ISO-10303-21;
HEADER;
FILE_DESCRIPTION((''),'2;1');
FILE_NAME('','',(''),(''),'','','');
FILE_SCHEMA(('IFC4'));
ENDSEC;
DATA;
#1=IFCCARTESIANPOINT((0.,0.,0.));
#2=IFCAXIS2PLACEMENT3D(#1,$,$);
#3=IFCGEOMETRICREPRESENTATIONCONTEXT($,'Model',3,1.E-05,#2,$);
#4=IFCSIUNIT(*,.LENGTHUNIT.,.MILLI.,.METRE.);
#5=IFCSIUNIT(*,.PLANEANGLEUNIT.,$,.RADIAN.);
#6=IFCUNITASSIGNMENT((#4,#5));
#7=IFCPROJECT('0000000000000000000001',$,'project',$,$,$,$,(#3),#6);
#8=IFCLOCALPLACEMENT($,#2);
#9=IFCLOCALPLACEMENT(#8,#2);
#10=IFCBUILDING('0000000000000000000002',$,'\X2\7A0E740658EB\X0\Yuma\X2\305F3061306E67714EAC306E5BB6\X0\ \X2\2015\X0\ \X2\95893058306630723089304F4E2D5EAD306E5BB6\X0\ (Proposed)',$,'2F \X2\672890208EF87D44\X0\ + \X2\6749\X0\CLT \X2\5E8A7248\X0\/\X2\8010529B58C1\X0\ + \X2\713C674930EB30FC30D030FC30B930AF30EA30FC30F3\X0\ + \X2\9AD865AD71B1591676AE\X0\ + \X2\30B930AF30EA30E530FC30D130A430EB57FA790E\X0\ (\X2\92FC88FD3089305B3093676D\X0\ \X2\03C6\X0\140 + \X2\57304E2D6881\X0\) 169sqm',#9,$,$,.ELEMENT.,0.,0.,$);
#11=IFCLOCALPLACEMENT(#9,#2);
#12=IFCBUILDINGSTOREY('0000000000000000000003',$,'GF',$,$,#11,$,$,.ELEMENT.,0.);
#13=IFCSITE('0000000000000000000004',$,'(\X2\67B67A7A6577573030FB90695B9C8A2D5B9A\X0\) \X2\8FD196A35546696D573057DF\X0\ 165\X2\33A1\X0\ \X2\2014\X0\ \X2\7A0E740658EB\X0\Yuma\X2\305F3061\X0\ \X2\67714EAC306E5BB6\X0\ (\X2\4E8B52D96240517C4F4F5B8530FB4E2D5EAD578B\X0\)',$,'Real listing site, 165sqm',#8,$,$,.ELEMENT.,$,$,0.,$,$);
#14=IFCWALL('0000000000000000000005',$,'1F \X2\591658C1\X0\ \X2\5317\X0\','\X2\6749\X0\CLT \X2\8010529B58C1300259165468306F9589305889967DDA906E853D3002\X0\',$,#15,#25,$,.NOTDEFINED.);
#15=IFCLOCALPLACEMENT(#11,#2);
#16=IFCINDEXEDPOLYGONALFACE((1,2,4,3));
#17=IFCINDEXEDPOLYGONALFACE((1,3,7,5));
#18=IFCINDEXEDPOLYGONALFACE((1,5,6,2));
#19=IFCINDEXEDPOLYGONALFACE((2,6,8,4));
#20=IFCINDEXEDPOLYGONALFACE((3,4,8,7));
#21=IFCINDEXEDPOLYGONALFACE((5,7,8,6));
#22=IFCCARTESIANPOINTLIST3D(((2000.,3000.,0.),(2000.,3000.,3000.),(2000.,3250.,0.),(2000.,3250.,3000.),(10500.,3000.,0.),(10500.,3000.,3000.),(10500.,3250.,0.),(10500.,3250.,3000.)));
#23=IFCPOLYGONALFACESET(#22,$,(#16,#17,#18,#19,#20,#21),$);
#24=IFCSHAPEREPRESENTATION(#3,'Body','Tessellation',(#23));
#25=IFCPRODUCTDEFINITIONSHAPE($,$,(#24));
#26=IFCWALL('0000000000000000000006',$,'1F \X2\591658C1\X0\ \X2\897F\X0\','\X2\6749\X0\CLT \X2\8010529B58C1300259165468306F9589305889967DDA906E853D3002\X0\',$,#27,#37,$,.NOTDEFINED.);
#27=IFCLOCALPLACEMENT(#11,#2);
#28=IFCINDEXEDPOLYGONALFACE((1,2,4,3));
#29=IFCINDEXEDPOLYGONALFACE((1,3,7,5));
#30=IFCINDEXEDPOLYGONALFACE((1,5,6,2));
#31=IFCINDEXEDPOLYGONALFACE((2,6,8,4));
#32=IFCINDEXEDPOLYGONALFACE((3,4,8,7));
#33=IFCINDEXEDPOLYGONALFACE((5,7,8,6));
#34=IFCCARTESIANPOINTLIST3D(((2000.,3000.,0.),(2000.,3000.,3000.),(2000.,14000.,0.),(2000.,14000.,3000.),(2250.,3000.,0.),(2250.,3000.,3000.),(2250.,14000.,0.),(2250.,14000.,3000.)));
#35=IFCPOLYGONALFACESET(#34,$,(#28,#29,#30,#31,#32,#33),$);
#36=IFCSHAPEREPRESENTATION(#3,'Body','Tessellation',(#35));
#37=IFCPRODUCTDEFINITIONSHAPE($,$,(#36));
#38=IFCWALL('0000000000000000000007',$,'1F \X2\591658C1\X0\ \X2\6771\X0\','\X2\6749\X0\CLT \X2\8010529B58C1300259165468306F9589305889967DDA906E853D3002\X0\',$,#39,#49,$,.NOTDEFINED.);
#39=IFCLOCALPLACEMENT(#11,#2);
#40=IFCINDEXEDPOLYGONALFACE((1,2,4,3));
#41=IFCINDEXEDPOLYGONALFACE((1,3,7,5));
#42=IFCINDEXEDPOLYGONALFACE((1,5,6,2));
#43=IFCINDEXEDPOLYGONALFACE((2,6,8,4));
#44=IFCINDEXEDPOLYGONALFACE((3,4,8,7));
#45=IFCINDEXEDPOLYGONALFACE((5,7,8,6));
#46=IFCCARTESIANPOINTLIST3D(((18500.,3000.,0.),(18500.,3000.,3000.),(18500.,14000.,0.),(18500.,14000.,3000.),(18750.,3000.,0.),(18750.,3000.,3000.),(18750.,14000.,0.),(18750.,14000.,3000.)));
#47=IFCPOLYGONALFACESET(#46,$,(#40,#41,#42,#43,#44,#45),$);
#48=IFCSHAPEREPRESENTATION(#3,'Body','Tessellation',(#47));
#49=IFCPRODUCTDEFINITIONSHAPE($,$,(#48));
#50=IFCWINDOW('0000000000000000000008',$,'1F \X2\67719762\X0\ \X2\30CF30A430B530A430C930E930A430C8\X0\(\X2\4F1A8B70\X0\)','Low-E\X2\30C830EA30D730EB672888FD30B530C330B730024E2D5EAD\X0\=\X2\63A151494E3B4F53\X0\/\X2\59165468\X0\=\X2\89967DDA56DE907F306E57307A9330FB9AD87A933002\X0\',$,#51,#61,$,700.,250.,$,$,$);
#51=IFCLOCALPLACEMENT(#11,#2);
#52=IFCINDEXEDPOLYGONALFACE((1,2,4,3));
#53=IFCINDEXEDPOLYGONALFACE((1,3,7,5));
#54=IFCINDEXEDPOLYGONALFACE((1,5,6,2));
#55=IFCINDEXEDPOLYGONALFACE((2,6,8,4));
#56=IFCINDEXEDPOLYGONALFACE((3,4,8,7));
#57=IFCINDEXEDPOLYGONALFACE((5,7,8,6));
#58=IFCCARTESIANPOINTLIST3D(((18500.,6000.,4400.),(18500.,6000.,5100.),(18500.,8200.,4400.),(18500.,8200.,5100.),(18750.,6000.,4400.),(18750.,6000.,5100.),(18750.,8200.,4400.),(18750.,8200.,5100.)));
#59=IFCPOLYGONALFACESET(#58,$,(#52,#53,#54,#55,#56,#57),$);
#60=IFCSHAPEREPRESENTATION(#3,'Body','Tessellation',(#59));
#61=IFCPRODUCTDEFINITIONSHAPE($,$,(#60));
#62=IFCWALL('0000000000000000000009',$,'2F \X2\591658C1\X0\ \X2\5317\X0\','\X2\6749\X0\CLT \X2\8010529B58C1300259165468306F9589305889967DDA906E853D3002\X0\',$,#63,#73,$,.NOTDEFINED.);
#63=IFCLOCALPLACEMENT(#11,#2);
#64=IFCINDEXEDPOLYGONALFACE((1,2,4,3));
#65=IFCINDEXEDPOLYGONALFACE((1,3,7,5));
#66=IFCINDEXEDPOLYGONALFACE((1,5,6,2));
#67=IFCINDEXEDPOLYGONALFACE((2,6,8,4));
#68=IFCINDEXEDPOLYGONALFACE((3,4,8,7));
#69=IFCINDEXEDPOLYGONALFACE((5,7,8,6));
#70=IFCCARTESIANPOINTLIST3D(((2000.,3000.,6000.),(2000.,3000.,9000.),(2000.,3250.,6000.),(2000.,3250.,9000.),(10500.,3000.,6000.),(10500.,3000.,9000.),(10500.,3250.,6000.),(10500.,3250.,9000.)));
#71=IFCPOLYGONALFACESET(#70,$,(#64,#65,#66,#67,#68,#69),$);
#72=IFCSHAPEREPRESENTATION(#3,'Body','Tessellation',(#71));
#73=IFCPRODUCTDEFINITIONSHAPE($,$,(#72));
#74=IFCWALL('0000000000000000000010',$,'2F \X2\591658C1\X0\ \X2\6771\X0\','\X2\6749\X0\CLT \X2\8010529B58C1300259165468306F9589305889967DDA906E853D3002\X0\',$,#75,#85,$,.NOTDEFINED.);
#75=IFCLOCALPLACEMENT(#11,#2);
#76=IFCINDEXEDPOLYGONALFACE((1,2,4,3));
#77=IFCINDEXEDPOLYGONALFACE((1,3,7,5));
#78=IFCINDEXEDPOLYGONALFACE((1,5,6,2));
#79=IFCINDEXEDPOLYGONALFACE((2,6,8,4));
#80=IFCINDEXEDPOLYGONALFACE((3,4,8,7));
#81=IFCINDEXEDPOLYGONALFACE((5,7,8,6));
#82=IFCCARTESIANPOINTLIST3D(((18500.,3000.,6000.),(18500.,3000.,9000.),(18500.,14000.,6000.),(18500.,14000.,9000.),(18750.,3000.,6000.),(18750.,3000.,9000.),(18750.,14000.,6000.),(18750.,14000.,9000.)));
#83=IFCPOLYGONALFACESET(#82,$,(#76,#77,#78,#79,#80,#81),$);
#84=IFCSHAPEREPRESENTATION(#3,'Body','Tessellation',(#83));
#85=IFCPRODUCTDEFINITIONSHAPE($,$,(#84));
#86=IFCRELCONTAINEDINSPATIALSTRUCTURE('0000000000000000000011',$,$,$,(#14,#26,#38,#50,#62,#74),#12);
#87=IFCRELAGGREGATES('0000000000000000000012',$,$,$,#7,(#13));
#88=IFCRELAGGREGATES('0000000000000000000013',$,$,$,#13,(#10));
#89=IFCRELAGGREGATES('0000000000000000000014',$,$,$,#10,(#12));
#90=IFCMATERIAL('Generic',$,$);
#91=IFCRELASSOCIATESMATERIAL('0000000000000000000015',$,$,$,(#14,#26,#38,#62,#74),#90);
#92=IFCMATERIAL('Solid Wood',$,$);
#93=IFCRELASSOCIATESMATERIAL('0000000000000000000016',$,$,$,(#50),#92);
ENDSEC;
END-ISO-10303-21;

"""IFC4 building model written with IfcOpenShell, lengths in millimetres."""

from ifc_helpers import new_model, si_unit, frame, frame_2d, origin, place, context, project, spatial, rectangle, extrude, material, element, fill, save


model = new_model("IFC4")

# Units and contexts
model_context = context("Model", 3, precision=1e-05, world=origin())
ifc_project = project(units=[si_unit("LENGTHUNIT", "METRE", prefix="MILLI"), si_unit("PLANEANGLEUNIT", "RADIAN")], contexts=[model_context])

# Site, building, storey
site_placement = place(None, origin())
site = spatial("IfcSite", under=ifc_project, at=site_placement, Name="(架空敷地・適宜設定) 近隣商業地域 165㎡ — 税理士Yumaたち 東京の家 (事務所兼住宅・中庭型)", ObjectType="Real listing site, 165sqm", CompositionType="ELEMENT", RefElevation=0.0)
building_placement = place(site_placement, origin())
building = spatial("IfcBuilding", under=site, at=building_placement, Name="税理士Yumaたちの東京の家 ― 閉じてひらく中庭の家 (Proposed)", ObjectType="2F 木造軸組 + 杉CLT 床版/耐力壁 + 焼杉ルーバースクリーン + 高断熱外皮 + スクリューパイル基礎 (鋼製らせん杭 φ140 + 地中梁) 169sqm", CompositionType="ELEMENT", ElevationOfRefHeight=0.0, ElevationOfTerrain=0.0)
storey_placement = place(building_placement, origin())
storey = spatial("IfcBuildingStorey", under=building, at=storey_placement, Name="GF", CompositionType="ELEMENT", Elevation=0.0)

# Shared definitions
ifc_material_1 = material(Name="Generic")

# Walls
wall_1_placement = place(storey_placement, frame((1000.0, 1500.0, 0.0)))
element("IfcWall", 1, at=wall_1_placement, inside=storey, material=ifc_material_1, Name="1F 外壁 北", Description="杉CLT 耐力壁。外周は閉じ視線遮蔽。", PredefinedType="NOTDEFINED", context=model_context, shape_type="SweptSolid", body=[
    extrude(rectangle(XDim=8500.0, YDim=250.0, at=frame_2d((4250.0, 125.0))), frame((1000.0, 1500.0, 0.0)), (0.0, 0.0, 1.0), 3000.0),
])
wall_2_placement = place(storey_placement, frame((1000.0, 1500.0, 0.0)))
element("IfcWall", 2, at=wall_2_placement, inside=storey, material=ifc_material_1, Name="1F 外壁 西", Description="杉CLT 耐力壁。外周は閉じ視線遮蔽。", PredefinedType="NOTDEFINED", context=model_context, shape_type="SweptSolid", body=[
    extrude(rectangle(XDim=250.0, YDim=11000.0, at=frame_2d((125.0, 5500.0))), frame((1000.0, 1500.0, 0.0)), (0.0, 0.0, 1.0), 3000.0),
])

# Wall, opening, window
wall_3_placement = place(storey_placement, frame((9250.0, 1500.0, 0.0)))
wall_3 = element("IfcWall", 3, at=wall_3_placement, inside=storey, material=ifc_material_1, Name="1F 外壁 東", Description="杉CLT 耐力壁。外周は閉じ視線遮蔽。", PredefinedType="NOTDEFINED", context=model_context, shape_type="SweptSolid", body=[
    extrude(rectangle(XDim=250.0, YDim=11000.0, at=frame_2d((125.0, 5500.0))), frame((9250.0, 1500.0, 0.0)), (0.0, 0.0, 1.0), 3000.0),
])
opening_1_placement = place(storey_placement, frame((9250.0, 3000.0, 2200.0)))
opening_1 = element("IfcOpeningElement", 4, at=opening_1_placement, cuts=wall_3, PredefinedType="NOTDEFINED", context=model_context, shape_type="SweptSolid", body=[
    extrude(rectangle(XDim=250.0, YDim=2200.0, at=frame_2d((125.0, 1100.0))), frame((9250.0, 3000.0, 2200.0)), (0.0, 0.0, 1.0), 700.0),
])
ifc_material_2 = material(Name="Solid Wood")
window_1_placement = place(storey_placement, frame((9250.0, 3000.0, 2200.0)))
window_1 = element("IfcWindow", 5, at=window_1_placement, inside=storey, material=ifc_material_2, Name="1F 東面 ハイサイドライト(会議)", Description="Low-Eトリプル木製サッシ。中庭=採光主体/外周=視線回避の地窓・高窓。", OverallHeight=700.0, OverallWidth=250.0, context=model_context, shape_type="SweptSolid", body=[
    extrude(rectangle(XDim=250.0, YDim=2200.0, at=frame_2d((125.0, 1100.0))), frame((9250.0, 3000.0, 2200.0)), (0.0, 0.0, 1.0), 700.0),
])
fill(opening_1, window_1)

# Wall
wall_4_placement = place(storey_placement, frame((1000.0, 1500.0, 3000.0)))
element("IfcWall", 6, at=wall_4_placement, inside=storey, material=ifc_material_1, Name="2F 外壁 北", Description="杉CLT 耐力壁。外周は閉じ視線遮蔽。", PredefinedType="NOTDEFINED", context=model_context, shape_type="SweptSolid", body=[
    extrude(rectangle(XDim=8500.0, YDim=250.0, at=frame_2d((4250.0, 125.0))), frame((1000.0, 1500.0, 3000.0)), (0.0, 0.0, 1.0), 3000.0),
])

# Wall
wall_5_placement = place(storey_placement, frame((9250.0, 1500.0, 3000.0)))
element("IfcWall", 7, at=wall_5_placement, inside=storey, material=ifc_material_1, Name="2F 外壁 東", Description="杉CLT 耐力壁。外周は閉じ視線遮蔽。", PredefinedType="NOTDEFINED", context=model_context, shape_type="SweptSolid", body=[
    extrude(rectangle(XDim=250.0, YDim=11000.0, at=frame_2d((125.0, 5500.0))), frame((9250.0, 1500.0, 3000.0)), (0.0, 0.0, 1.0), 3000.0),
])

save(model, "model.ifc")
